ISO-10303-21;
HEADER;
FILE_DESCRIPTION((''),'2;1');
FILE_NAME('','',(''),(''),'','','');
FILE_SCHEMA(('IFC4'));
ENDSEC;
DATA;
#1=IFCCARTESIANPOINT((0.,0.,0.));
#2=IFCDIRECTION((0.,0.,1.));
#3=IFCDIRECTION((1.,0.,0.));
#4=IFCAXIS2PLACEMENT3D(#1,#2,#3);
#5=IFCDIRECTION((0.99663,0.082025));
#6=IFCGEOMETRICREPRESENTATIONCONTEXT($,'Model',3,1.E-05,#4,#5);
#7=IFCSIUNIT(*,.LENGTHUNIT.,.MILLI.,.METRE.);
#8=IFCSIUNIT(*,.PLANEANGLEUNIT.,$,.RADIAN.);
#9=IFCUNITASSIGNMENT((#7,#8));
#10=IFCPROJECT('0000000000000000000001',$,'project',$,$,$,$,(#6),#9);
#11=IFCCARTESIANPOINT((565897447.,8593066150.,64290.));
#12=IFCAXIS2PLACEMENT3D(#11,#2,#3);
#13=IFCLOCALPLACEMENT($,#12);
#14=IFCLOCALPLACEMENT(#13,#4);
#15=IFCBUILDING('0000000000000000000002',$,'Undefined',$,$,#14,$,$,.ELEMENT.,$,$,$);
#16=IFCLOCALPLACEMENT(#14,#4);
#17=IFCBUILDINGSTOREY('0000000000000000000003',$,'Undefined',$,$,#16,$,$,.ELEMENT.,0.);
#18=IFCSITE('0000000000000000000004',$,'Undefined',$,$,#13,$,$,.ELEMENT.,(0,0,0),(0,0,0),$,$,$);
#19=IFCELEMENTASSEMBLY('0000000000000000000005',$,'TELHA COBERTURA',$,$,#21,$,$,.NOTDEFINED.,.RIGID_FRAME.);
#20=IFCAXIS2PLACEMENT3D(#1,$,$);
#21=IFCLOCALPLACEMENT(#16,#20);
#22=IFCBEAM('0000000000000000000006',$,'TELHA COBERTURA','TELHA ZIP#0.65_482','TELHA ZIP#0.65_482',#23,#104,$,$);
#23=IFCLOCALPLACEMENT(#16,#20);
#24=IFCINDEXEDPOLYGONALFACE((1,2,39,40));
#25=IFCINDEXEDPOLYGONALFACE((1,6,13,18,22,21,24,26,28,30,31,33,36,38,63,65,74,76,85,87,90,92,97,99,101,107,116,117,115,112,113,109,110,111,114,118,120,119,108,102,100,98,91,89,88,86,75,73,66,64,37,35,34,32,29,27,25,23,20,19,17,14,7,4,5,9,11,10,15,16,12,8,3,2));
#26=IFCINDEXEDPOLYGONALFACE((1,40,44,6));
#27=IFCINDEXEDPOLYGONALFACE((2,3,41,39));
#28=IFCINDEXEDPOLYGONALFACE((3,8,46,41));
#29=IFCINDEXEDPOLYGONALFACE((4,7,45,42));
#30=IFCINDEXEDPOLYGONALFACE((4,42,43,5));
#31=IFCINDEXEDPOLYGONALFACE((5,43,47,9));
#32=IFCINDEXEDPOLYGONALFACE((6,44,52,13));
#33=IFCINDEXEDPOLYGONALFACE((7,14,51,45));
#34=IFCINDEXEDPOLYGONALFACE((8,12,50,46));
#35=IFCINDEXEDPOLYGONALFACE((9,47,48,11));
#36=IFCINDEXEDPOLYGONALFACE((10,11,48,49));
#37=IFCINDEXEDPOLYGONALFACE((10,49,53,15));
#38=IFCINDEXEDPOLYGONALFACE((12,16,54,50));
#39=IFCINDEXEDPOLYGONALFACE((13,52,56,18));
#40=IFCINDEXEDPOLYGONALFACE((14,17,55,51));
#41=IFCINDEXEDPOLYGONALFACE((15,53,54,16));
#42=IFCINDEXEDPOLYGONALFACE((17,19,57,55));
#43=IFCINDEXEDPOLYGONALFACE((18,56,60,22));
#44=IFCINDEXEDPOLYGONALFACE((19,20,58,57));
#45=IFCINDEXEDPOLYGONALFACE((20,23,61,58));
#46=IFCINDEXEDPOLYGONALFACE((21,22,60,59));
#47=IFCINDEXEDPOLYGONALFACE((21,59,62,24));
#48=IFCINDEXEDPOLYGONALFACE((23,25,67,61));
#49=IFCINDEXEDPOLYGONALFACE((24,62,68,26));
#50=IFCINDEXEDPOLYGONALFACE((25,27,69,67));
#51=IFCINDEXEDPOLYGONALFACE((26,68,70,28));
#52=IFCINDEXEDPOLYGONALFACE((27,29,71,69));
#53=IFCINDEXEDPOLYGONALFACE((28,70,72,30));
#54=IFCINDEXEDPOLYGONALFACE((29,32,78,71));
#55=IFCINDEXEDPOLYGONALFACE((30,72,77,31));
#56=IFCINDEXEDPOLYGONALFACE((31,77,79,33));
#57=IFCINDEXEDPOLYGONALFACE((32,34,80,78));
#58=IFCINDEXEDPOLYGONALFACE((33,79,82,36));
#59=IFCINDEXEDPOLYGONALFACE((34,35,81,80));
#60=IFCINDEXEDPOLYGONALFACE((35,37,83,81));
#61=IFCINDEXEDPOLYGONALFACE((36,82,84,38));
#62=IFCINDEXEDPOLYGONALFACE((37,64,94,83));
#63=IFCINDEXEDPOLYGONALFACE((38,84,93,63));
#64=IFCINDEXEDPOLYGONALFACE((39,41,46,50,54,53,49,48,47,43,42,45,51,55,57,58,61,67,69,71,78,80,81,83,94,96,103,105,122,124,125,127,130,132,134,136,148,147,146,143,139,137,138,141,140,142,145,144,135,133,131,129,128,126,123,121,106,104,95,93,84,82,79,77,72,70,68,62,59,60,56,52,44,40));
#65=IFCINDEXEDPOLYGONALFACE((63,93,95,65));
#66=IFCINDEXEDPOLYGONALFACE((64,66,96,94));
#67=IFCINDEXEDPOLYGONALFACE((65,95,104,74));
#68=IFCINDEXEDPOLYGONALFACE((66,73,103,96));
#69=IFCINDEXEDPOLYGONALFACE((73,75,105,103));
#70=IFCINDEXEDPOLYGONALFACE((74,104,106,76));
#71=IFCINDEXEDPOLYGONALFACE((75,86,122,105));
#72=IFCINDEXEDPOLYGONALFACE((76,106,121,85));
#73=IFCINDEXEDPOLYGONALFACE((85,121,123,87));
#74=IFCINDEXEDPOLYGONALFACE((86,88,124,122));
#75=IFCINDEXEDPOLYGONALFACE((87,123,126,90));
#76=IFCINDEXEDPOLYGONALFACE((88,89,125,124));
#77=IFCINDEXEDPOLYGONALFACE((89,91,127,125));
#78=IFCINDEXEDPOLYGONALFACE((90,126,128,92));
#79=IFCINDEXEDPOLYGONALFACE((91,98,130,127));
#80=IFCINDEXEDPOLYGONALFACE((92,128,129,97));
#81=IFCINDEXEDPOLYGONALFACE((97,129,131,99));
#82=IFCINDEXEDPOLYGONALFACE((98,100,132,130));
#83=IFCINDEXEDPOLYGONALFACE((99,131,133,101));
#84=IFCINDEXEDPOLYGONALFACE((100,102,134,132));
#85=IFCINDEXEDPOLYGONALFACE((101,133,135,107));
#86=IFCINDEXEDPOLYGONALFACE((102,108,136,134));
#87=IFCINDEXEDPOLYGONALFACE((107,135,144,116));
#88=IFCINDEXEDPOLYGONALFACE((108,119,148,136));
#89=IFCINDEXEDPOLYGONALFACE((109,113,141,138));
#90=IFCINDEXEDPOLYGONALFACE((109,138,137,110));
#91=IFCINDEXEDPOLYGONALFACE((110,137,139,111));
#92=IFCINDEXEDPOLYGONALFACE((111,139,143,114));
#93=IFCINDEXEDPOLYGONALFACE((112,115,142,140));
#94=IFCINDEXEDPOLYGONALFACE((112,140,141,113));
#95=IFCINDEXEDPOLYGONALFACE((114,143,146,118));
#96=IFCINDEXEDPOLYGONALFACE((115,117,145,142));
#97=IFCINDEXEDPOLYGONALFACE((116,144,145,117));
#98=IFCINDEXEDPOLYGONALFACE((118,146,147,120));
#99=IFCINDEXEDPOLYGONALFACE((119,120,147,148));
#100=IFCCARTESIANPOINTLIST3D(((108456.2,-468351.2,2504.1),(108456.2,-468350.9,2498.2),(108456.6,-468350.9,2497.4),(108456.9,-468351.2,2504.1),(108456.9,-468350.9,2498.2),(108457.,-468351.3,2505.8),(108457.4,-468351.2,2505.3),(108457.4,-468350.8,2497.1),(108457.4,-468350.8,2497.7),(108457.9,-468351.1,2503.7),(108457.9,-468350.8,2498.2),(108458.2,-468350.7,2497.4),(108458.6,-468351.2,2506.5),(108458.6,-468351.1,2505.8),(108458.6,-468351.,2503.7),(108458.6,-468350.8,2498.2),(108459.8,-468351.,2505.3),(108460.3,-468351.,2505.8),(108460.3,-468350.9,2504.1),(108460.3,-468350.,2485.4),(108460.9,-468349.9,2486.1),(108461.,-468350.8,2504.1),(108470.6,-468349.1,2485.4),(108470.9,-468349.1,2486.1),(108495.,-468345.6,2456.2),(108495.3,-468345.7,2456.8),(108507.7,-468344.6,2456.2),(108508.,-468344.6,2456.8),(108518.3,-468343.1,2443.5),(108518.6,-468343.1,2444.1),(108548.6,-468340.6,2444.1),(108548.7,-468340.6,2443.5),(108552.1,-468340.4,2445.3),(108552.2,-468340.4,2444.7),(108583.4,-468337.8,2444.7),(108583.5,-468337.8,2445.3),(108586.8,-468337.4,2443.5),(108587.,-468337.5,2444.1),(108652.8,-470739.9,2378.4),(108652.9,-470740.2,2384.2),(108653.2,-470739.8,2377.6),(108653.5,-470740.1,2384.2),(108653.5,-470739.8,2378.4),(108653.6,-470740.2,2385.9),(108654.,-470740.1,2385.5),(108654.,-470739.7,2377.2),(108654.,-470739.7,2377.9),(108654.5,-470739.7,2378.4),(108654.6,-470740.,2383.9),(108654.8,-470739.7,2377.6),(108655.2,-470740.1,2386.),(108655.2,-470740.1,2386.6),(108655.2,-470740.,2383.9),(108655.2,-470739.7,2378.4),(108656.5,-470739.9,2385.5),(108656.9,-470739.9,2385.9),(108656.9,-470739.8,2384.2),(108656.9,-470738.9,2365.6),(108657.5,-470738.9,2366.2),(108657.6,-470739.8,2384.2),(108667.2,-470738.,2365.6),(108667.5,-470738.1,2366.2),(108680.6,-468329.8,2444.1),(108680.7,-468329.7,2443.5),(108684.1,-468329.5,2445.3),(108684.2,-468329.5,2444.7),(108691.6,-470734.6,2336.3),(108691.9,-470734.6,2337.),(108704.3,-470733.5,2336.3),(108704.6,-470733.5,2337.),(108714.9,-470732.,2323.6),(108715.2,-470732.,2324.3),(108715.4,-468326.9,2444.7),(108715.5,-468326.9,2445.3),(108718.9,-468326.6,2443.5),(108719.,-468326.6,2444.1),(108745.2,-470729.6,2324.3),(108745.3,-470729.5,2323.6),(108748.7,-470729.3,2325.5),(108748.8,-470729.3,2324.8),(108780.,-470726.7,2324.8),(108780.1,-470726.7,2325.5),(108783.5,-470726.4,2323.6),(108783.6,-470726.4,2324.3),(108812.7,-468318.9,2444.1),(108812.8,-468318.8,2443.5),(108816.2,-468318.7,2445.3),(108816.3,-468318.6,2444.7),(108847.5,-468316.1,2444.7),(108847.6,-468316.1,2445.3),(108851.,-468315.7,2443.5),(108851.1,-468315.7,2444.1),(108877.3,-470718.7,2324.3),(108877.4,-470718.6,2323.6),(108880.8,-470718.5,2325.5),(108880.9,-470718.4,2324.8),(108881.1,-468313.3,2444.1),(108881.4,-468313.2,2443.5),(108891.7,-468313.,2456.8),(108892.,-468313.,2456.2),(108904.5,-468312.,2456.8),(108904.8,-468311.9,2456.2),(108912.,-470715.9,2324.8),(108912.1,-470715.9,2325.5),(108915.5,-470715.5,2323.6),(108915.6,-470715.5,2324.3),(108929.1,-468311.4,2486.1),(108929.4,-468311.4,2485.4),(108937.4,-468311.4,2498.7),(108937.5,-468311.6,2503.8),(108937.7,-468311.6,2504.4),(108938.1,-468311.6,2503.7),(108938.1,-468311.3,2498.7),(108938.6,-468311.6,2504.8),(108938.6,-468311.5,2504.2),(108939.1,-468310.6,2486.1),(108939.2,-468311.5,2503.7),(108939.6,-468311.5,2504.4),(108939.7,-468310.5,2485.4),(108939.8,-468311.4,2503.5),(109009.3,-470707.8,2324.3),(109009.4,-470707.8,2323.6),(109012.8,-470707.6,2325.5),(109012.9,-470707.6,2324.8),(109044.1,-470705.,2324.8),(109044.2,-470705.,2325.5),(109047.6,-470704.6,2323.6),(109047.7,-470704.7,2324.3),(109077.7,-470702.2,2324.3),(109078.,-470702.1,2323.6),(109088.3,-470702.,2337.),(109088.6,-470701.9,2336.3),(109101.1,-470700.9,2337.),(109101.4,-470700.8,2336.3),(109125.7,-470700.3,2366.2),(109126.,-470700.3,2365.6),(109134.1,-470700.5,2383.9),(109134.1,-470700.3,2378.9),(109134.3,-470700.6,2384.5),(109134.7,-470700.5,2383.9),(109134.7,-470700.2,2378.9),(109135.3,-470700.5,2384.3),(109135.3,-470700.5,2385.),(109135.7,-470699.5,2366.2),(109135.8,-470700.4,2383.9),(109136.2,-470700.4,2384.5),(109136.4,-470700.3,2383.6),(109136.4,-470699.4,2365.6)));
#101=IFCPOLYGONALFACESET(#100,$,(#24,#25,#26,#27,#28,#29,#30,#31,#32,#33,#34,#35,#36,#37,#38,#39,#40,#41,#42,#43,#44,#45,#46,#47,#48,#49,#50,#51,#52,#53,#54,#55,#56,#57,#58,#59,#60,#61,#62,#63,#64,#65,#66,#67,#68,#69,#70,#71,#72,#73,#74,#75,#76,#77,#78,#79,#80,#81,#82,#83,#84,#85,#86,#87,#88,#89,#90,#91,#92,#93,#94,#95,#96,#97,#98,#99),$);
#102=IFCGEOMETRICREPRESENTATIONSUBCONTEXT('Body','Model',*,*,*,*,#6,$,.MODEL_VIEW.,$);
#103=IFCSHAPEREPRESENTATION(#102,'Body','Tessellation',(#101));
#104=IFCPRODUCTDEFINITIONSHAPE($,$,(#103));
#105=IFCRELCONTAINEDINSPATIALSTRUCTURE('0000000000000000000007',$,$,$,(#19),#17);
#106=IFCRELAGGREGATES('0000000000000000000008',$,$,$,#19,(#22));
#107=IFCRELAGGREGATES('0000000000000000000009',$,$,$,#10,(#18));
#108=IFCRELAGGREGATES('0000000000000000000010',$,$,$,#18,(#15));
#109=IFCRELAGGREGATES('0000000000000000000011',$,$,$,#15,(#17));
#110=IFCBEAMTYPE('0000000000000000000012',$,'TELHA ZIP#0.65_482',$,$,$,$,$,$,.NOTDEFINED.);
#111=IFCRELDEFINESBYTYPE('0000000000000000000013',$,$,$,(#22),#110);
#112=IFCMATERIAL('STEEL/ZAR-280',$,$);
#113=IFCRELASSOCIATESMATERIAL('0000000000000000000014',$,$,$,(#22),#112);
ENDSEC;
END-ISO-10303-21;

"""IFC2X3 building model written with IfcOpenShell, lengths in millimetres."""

from ifc_helpers import new_model, si_unit, direction, frame, origin_with_axes, place, context, subcontext, project, spatial, polyline, outline, extrude, material, type_object, element, aggregate, save


model = new_model("IFC2X3")

# Units and contexts
model_context = context("Model", 3, precision=1e-05, world=origin_with_axes(), true_north=direction((0.99663, 0.082025)))
body_context = subcontext(model_context, "Body", "Model", "MODEL_VIEW")
ifc_project = project(units=[si_unit("LENGTHUNIT", "METRE", prefix="MILLI"), si_unit("PLANEANGLEUNIT", "RADIAN")], contexts=[model_context])

# Site, building, storey
site_placement = place(None, frame((565897447.0, 8593066150.0, 64290.0), z_axis=(0.0, 0.0, 1.0), x_axis=(1.0, 0.0, 0.0)))
site = spatial("IfcSite", under=ifc_project, at=site_placement, Name="Undefined", CompositionType="ELEMENT", RefLatitude=(0, 0, 0), RefLongitude=(0, 0, 0))
building_placement = place(site_placement, origin_with_axes())
building = spatial("IfcBuilding", under=site, at=building_placement, Name="Undefined", CompositionType="ELEMENT")
storey_placement = place(building_placement, origin_with_axes())
storey = spatial("IfcBuildingStorey", under=building, at=storey_placement, Name="Undefined", CompositionType="ELEMENT", Elevation=0.0)

# Element assembly, beam
ifc_material_1 = material(Name="STEEL/ZAR-280")
beam_type_1 = type_object("IfcBeamType", Name="TELHA ZIP#0.65_482", PredefinedType="NOTDEFINED")
assembly_1_placement = place(storey_placement, origin_with_axes())
assembly_1 = element("IfcElementAssembly", 1, at=assembly_1_placement, inside=storey, Name="TELHA COBERTURA", AssemblyPlace="NOTDEFINED", PredefinedType="RIGID_FRAME")
beam_1_placement = place(assembly_1_placement, frame((108894.5, -470718.8, 2354.8), z_axis=(0.004096, -0.049769, 0.998752), x_axis=(-0.081923, 0.995387, 0.049938)))
beam_1 = element("IfcBeam", 2, at=beam_1_placement, type_object=beam_type_1, material=ifc_material_1, Name="TELHA COBERTURA", Description="TELHA ZIP#0.65_482", ObjectType="TELHA ZIP#0.65_482", context=body_context, shape_type="SweptSolid", body=[
    extrude(outline(polyline([(240.5, 29.7), (241.4, 30.2), (242.4, 29.7), (242.6, 28.9), (242.6, 10.8), (232.2, 10.8), (207.6, -18.5), (194.9, -18.5), (184.2, -31.2), (153.7, -31.2), (150.2, -30.0), (118.9, -30.0), (115.4, -31.2), (21.2, -31.2), (17.7, -30.0), (-13.6, -30.0), (-17.1, -31.2), (-111.3, -31.2), (-114.8, -30.0), (-146.1, -30.0), (-149.6, -31.2), (-180.1, -31.2), (-190.8, -18.5), (-203.6, -18.5), (-228.1, 10.8), (-238.5, 10.8), (-238.5, 29.5), (-239.0, 30.7), (-240.2, 31.2), (-241.4, 30.7), (-241.9, 29.5), (-241.9, 23.6), (-241.4, 23.1), (-240.9, 23.6), (-240.9, 29.1), (-240.2, 29.1), (-240.2, 23.6), (-240.6, 22.8), (-241.4, 22.4), (-242.3, 22.8), (-242.6, 23.6), (-242.6, 29.5), (-241.9, 31.2), (-240.2, 31.9), (-238.5, 31.2), (-237.9, 29.5), (-237.9, 11.4), (-227.8, 11.4), (-203.2, -17.9), (-190.4, -17.9), (-179.8, -30.5), (-149.7, -30.5), (-146.2, -29.4), (-114.7, -29.4), (-111.2, -30.5), (-17.2, -30.5), (-13.7, -29.4), (17.8, -29.4), (21.3, -30.5), (115.3, -30.5), (118.8, -29.4), (150.3, -29.4), (153.8, -30.5), (183.9, -30.5), (194.6, -17.9), (207.4, -17.9), (231.9, 11.4), (241.9, 11.4), (241.9, 29.1), (241.4, 29.5), (240.9, 29.1), (240.9, 24.1), (240.2, 24.1), (240.2, 29.2), (240.5, 29.7)])), frame((2400.0, 0.0, 0.0), z_axis=(-1.0, 0.0, 0.0), x_axis=(0.0, -1.0, 0.0)), (0.0, 0.0, 1.0), 2400.0),
])
aggregate(assembly_1, [beam_1])

save(model, "model.ifc")
